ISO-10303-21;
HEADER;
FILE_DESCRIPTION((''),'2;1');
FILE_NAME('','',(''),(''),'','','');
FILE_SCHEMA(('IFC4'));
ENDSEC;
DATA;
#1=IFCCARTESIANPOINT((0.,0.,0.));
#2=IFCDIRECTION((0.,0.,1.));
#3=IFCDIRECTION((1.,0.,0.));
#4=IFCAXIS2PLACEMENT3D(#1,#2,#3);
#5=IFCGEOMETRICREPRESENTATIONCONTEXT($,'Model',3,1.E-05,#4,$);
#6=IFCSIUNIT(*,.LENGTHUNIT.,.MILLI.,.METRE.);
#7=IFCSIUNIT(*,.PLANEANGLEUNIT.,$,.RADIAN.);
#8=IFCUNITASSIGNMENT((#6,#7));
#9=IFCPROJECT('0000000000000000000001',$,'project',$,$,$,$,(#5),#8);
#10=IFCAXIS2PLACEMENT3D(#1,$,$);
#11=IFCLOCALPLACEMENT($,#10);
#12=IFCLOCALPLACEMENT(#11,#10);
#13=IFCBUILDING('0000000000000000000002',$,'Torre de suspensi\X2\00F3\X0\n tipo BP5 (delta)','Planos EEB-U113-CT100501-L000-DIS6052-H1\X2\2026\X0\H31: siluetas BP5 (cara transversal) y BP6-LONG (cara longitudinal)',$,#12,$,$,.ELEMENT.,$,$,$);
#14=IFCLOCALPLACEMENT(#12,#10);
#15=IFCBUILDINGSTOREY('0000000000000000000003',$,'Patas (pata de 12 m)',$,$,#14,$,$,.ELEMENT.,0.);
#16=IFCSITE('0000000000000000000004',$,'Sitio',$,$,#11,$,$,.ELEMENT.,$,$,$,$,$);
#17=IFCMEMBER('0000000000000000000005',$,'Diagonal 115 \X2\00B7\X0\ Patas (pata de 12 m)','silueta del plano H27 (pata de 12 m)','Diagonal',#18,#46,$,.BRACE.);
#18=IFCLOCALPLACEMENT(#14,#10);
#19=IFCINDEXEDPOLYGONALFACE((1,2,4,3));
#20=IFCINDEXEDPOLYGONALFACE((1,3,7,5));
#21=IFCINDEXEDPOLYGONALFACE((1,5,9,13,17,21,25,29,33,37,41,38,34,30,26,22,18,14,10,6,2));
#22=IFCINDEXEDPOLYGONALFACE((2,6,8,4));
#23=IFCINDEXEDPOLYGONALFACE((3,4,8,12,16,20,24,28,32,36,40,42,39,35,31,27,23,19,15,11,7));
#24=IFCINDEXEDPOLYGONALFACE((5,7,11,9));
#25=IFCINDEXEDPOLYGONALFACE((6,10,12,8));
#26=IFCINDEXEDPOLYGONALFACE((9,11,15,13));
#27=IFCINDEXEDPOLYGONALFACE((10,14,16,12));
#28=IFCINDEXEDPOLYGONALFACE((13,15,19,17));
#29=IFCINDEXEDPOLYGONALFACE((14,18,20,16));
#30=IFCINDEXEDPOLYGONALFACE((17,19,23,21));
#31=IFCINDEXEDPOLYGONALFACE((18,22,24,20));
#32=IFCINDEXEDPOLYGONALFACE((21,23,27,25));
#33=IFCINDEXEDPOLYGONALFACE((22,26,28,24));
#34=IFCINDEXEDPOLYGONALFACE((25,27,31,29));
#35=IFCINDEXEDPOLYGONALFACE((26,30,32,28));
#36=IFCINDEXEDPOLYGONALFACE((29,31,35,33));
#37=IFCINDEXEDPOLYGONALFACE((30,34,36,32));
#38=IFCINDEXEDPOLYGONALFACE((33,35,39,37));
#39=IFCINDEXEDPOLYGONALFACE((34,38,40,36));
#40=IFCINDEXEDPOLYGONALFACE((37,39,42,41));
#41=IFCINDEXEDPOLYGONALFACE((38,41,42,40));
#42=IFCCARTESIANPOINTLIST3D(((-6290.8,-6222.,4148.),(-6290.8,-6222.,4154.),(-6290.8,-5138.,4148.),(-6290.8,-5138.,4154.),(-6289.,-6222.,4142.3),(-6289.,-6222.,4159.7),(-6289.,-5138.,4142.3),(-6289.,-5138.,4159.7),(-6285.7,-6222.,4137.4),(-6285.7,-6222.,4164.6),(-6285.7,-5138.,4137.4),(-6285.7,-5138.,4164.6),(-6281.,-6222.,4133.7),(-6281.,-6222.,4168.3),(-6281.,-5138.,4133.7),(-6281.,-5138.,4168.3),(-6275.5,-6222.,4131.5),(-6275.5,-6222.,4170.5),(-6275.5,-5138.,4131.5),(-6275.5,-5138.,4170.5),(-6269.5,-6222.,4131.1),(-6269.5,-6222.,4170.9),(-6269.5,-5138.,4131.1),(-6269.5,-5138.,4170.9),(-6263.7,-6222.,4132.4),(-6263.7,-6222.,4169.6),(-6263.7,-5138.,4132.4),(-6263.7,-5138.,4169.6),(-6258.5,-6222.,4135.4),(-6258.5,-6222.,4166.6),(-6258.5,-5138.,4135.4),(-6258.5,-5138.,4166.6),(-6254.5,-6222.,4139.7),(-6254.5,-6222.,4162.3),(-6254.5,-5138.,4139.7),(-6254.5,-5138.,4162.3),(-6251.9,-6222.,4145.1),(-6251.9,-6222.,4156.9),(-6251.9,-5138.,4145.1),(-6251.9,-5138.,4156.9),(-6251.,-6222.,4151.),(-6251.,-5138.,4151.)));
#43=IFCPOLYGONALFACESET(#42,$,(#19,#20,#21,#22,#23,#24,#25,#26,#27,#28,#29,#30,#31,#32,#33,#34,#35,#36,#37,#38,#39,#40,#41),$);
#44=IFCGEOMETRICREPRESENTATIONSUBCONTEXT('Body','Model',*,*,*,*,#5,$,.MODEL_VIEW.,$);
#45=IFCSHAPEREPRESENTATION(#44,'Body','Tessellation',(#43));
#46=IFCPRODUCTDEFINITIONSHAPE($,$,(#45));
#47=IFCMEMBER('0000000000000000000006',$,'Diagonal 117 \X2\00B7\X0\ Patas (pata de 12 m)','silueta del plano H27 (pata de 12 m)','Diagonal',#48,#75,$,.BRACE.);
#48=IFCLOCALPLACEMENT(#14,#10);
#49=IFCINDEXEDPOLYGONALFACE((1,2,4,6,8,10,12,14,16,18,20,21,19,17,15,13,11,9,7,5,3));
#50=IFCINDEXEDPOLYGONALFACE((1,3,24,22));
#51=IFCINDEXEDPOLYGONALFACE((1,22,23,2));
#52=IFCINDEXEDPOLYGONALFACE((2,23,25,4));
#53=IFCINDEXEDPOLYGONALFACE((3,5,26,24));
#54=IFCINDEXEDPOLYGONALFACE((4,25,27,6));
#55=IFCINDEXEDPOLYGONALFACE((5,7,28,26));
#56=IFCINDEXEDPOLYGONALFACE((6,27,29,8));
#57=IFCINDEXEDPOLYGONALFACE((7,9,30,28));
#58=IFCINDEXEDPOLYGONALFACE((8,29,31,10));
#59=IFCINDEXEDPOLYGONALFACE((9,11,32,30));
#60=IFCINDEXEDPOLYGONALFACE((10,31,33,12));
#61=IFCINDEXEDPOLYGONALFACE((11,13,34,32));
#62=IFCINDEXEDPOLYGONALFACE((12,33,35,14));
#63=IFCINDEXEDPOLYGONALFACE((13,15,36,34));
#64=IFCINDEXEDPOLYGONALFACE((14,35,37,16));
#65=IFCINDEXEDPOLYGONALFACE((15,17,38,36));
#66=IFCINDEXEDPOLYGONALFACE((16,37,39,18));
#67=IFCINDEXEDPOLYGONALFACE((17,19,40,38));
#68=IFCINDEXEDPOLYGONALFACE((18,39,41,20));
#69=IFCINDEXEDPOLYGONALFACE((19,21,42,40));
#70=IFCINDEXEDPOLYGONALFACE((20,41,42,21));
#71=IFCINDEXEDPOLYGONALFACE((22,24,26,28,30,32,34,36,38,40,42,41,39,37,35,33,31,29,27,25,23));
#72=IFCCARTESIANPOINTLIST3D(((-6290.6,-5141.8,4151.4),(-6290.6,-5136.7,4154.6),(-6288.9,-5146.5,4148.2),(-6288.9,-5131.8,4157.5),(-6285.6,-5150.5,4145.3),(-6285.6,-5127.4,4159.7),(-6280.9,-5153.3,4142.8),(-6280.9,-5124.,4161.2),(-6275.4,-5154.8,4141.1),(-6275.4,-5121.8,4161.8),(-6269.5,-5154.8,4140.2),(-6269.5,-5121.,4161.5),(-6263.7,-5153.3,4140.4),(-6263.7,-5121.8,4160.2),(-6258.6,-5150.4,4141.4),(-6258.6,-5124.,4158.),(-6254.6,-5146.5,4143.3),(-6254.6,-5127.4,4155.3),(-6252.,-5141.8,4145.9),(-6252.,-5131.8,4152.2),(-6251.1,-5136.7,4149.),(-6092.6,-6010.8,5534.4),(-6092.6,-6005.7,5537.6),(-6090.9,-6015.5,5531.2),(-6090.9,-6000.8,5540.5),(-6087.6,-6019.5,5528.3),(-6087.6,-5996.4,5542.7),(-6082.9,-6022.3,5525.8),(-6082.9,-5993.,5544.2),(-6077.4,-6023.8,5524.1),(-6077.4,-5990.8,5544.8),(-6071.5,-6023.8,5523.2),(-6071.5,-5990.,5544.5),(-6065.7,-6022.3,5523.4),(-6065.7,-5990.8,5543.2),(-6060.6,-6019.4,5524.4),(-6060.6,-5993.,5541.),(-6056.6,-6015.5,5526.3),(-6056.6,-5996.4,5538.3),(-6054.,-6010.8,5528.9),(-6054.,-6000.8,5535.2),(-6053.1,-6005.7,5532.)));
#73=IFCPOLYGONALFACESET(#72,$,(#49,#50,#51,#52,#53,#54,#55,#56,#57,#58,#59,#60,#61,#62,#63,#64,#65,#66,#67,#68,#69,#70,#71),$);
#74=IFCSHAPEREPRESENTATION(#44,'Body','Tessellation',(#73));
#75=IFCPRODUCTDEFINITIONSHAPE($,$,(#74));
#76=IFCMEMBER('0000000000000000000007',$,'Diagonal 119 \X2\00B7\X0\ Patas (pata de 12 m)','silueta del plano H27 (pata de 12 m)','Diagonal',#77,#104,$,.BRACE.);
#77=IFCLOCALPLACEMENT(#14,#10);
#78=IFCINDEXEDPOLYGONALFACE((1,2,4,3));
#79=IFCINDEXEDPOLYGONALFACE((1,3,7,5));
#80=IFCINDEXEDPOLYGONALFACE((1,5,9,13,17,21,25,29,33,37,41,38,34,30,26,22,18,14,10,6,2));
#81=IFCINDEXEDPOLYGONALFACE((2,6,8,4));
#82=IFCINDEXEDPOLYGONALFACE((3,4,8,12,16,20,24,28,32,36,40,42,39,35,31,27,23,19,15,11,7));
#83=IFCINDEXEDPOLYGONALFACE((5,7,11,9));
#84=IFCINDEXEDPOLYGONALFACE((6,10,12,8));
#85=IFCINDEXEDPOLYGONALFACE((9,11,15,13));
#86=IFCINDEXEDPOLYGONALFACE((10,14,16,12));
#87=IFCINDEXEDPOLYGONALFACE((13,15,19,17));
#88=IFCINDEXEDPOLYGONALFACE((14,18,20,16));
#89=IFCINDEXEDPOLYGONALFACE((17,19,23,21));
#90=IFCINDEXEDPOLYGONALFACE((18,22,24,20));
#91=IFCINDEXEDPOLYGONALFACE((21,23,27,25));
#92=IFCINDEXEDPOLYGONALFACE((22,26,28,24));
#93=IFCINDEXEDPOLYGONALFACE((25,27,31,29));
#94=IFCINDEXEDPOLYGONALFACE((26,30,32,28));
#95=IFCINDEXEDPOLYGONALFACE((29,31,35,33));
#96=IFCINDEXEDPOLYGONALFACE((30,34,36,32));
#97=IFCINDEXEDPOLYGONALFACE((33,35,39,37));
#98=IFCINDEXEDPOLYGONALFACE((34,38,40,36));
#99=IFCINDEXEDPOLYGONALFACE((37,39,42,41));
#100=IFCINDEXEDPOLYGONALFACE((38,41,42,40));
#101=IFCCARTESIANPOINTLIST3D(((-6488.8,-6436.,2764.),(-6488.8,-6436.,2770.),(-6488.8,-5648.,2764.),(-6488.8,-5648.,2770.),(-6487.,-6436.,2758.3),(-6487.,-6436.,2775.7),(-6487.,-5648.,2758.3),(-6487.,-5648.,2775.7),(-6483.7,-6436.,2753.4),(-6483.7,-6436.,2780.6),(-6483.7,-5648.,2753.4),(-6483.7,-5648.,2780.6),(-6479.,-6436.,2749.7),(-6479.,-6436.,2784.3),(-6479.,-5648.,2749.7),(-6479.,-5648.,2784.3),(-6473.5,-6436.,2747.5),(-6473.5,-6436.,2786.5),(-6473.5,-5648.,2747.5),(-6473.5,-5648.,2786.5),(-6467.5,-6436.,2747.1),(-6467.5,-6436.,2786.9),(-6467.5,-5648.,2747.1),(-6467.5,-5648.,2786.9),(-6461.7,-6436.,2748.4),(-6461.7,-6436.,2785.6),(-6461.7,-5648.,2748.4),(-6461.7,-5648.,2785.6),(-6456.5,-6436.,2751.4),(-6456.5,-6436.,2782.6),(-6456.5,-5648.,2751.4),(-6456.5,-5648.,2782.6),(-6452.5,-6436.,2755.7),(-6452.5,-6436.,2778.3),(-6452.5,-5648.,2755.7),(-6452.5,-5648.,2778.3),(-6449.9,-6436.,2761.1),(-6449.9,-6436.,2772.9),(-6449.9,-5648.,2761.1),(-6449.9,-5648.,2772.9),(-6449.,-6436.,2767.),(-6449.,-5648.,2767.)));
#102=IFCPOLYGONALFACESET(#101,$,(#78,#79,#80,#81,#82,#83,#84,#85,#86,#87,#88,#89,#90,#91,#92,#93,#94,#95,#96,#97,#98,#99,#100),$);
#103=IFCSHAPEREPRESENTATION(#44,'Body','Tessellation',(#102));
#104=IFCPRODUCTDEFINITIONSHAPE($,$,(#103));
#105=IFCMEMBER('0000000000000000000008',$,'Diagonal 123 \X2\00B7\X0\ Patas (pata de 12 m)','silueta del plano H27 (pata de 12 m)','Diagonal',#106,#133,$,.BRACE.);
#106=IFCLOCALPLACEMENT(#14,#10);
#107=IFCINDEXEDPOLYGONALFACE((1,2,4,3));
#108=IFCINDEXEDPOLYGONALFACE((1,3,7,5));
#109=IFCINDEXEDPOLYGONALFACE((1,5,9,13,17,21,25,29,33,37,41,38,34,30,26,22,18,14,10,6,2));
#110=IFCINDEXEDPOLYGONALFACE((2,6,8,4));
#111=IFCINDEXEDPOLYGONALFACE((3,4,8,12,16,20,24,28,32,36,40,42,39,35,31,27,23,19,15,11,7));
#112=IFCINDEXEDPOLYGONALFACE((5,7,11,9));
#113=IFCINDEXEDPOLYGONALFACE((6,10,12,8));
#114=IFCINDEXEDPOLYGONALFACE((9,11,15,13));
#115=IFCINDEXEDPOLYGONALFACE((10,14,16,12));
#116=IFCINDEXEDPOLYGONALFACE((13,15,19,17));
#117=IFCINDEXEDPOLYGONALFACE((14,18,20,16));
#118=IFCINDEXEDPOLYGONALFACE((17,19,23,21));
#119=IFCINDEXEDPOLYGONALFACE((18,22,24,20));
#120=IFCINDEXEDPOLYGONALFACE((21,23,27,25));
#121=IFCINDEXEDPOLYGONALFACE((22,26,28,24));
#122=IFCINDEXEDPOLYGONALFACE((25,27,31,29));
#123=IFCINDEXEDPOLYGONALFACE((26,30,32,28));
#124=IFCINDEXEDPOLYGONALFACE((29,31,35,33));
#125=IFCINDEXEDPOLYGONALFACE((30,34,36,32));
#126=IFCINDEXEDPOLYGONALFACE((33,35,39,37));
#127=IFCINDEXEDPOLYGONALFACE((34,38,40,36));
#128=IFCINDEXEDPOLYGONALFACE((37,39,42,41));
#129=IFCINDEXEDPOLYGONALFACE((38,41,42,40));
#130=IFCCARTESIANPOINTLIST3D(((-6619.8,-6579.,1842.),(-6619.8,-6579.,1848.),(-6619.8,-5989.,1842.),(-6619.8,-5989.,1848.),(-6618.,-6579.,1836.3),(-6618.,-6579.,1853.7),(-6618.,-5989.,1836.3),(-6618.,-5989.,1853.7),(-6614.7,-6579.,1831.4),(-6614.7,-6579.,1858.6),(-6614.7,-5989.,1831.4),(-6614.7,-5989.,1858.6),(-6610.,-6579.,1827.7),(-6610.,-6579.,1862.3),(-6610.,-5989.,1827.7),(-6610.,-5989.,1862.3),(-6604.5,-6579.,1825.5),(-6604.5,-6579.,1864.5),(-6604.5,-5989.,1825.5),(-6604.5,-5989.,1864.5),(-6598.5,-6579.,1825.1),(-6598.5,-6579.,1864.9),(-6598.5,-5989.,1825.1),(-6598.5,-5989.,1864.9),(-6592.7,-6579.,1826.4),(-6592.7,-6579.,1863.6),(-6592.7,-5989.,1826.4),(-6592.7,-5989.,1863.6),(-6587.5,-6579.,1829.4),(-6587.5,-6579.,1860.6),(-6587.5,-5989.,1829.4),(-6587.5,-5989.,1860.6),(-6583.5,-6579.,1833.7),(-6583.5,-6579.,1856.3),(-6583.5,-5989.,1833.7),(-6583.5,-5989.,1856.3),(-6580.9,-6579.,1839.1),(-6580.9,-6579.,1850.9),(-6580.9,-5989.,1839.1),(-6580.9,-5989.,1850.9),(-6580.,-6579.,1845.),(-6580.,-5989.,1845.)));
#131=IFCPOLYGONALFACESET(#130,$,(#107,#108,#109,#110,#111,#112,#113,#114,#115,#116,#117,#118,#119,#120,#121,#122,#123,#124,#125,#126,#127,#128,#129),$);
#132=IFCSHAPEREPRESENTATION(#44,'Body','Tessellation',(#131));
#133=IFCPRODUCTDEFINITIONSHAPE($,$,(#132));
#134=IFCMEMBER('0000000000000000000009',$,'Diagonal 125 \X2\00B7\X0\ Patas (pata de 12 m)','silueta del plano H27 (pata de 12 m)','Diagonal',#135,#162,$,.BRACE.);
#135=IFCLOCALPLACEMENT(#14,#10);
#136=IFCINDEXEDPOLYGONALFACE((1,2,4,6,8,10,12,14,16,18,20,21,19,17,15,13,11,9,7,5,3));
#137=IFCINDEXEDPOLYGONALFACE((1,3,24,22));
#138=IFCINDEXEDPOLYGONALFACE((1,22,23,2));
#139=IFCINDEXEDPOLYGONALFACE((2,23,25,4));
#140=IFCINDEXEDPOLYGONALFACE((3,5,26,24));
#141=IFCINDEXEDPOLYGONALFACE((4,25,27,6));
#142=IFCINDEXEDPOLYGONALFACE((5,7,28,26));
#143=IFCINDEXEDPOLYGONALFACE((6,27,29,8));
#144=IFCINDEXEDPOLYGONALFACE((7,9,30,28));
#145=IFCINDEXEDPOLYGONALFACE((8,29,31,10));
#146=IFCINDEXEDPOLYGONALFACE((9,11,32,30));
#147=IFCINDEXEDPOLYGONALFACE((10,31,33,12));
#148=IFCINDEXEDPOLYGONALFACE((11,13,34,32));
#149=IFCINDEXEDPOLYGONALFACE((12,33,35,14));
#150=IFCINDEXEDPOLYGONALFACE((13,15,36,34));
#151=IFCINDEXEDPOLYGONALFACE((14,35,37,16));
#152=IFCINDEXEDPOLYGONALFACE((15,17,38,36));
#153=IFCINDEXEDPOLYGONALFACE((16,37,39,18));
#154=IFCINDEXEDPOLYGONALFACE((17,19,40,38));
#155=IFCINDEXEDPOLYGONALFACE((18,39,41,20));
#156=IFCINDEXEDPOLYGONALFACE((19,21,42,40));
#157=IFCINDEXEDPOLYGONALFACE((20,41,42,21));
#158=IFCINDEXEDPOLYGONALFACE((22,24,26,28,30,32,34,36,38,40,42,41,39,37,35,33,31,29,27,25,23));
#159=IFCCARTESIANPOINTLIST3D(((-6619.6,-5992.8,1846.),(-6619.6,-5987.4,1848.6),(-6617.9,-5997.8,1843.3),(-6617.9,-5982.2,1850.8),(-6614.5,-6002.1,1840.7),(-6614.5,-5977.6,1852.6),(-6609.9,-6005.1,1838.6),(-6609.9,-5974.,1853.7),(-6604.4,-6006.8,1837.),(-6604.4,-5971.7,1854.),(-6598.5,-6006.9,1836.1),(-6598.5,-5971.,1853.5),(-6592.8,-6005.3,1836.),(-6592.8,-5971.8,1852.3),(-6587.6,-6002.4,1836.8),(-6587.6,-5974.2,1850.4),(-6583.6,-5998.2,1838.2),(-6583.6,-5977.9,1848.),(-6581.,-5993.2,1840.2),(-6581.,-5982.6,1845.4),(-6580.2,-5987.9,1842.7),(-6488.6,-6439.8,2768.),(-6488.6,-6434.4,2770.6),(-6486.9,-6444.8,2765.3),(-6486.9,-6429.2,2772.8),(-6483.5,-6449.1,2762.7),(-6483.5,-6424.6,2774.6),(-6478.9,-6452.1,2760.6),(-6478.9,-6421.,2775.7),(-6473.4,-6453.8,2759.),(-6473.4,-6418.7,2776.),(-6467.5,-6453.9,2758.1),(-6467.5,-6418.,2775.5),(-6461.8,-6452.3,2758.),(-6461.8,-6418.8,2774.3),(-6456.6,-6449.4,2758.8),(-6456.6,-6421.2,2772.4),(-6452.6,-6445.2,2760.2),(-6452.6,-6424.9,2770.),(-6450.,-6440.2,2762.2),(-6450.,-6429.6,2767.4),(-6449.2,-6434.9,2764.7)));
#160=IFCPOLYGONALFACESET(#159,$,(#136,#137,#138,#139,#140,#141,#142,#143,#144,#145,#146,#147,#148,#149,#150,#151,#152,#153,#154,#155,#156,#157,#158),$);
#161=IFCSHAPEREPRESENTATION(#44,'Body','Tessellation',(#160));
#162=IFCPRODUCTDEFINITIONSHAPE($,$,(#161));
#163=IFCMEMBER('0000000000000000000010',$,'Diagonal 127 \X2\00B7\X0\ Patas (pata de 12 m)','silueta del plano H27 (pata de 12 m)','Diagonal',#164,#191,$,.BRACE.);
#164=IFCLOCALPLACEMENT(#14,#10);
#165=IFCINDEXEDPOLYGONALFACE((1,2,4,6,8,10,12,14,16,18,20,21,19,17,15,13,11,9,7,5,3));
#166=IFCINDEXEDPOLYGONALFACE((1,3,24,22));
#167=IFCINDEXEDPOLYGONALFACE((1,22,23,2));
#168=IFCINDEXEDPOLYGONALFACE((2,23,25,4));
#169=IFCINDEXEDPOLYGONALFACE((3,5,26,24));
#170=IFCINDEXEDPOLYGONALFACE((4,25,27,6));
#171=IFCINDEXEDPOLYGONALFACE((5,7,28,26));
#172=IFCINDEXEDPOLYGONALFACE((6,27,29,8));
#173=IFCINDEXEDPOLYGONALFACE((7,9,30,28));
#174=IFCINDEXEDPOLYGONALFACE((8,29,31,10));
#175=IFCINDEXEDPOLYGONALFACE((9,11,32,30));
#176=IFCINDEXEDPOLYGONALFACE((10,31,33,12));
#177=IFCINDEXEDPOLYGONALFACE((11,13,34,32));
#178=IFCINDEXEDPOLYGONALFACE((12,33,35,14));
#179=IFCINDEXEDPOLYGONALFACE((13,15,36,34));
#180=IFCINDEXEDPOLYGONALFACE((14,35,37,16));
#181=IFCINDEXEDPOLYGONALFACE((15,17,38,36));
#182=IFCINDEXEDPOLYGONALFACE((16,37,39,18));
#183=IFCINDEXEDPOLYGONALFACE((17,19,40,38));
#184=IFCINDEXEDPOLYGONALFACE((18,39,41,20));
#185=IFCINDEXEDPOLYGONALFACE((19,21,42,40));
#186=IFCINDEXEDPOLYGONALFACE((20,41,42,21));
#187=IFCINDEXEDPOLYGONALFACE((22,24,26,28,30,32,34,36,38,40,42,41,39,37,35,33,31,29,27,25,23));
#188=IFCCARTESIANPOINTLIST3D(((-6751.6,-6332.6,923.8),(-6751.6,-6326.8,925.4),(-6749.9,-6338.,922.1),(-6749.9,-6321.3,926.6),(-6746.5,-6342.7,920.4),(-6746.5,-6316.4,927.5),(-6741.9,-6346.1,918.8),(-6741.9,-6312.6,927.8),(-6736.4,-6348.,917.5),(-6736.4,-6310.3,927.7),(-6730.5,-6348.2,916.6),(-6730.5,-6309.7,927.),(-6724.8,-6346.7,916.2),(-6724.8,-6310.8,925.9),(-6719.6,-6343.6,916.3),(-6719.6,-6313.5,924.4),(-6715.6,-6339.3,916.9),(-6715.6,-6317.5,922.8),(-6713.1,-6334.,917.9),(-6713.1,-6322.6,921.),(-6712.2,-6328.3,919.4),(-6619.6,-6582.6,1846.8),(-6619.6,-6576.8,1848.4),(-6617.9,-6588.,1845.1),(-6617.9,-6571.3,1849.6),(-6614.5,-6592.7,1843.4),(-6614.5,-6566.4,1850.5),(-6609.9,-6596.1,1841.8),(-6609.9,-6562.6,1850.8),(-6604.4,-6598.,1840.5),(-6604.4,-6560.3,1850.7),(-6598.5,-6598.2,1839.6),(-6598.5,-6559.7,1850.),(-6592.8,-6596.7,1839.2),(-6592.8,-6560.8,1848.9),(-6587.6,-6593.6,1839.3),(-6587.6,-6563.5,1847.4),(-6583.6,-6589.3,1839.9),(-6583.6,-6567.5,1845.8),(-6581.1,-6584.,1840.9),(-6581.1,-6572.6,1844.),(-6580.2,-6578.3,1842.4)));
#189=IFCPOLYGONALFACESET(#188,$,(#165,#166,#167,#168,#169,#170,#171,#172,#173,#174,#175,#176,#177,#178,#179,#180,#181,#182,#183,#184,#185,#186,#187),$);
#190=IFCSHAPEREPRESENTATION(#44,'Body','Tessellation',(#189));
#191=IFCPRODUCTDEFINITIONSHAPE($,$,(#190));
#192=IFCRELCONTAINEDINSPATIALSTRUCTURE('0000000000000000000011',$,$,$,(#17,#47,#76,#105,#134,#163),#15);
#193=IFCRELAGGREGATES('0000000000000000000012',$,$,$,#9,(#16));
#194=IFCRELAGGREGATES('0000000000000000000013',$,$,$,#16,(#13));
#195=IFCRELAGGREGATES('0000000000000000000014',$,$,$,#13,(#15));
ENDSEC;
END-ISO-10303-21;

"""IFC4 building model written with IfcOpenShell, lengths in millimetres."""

from ifc_helpers import new_model, si_unit, frame, origin, origin_with_axes, place, context, subcontext, project, spatial, circle, extrude, element, save


model = new_model("IFC4")

# Units and contexts
model_context = context("Model", 3, precision=1e-05, world=origin_with_axes())
body_context = subcontext(model_context, "Body", "Model", "MODEL_VIEW")
ifc_project = project(units=[si_unit("LENGTHUNIT", "METRE", prefix="MILLI"), si_unit("PLANEANGLEUNIT", "RADIAN")], contexts=[model_context])

# Site, building, storey
site_placement = place(None, origin())
site = spatial("IfcSite", under=ifc_project, at=site_placement, Name="Sitio", CompositionType="ELEMENT")
building_placement = place(site_placement, origin())
building = spatial("IfcBuilding", under=site, at=building_placement, Name="Torre de suspensión tipo BP5 (delta)", Description="Planos EEB-U113-CT100501-L000-DIS6052-H1…H31: siluetas BP5 (cara transversal) y BP6-LONG (cara longitudinal)", CompositionType="ELEMENT")
storey_placement = place(building_placement, origin())
storey = spatial("IfcBuildingStorey", under=building, at=storey_placement, Name="Patas (pata de 12 m)", CompositionType="ELEMENT", Elevation=0.0)

# Members
member_1_placement = place(storey_placement, frame((-6271.0, -6222.0, 4151.0), z_axis=(0.0, 1.0, 0.0), x_axis=(1.0, 0.0, 0.0)))
element("IfcMember", 1, at=member_1_placement, inside=storey, Name="Diagonal 115 · Patas (pata de 12 m)", Description="silueta del plano H27 (pata de 12 m)", ObjectType="Diagonal", PredefinedType="BRACE", context=body_context, shape_type="SweptSolid", body=[
    extrude(circle(Radius=20.0), None, (0.0, 0.0, 1.0), 1084.0),
])
member_2_placement = place(storey_placement, frame((-6271.0, -5138.0, 4151.0), z_axis=(0.120342, -0.528167, 0.84057), x_axis=(0.992733, 0.064026, -0.101896)))
element("IfcMember", 2, at=member_2_placement, inside=storey, Name="Diagonal 117 · Patas (pata de 12 m)", Description="silueta del plano H27 (pata de 12 m)", ObjectType="Diagonal", PredefinedType="BRACE", context=body_context, shape_type="SweptSolid", body=[
    extrude(circle(Radius=20.0), None, (0.0, 0.0, 1.0), 1645.3),
])
member_3_placement = place(storey_placement, frame((-6469.0, -6436.0, 2767.0), z_axis=(0.0, 1.0, 0.0), x_axis=(1.0, 0.0, 0.0)))
element("IfcMember", 3, at=member_3_placement, inside=storey, Name="Diagonal 119 · Patas (pata de 12 m)", Description="silueta del plano H27 (pata de 12 m)", ObjectType="Diagonal", PredefinedType="BRACE", context=body_context, shape_type="SweptSolid", body=[
    extrude(circle(Radius=20.0), None, (0.0, 0.0, 1.0), 788.0),
])
member_4_placement = place(storey_placement, frame((-6600.0, -6579.0, 1845.0), z_axis=(0.0, 1.0, 0.0), x_axis=(1.0, 0.0, 0.0)))
element("IfcMember", 4, at=member_4_placement, inside=storey, Name="Diagonal 123 · Patas (pata de 12 m)", Description="silueta del plano H27 (pata de 12 m)", ObjectType="Diagonal", PredefinedType="BRACE", context=body_context, shape_type="SweptSolid", body=[
    extrude(circle(Radius=20.0), None, (0.0, 0.0, 1.0), 590.0),
])
member_5_placement = place(storey_placement, frame((-6600.0, -5989.0, 1845.0), z_axis=(0.126817, -0.432727, 0.892561), x_axis=(0.991926, 0.055324, -0.114113)))
element("IfcMember", 5, at=member_5_placement, inside=storey, Name="Diagonal 125 · Patas (pata de 12 m)", Description="silueta del plano H27 (pata de 12 m)", ObjectType="Diagonal", PredefinedType="BRACE", context=body_context, shape_type="SweptSolid", body=[
    extrude(circle(Radius=20.0), None, (0.0, 0.0, 1.0), 1033.0),
])
member_6_placement = place(storey_placement, frame((-6732.0, -6329.0, 922.0), z_axis=(0.136741, -0.25898, 0.956154), x_axis=(0.990607, 0.035749, -0.131986)))
element("IfcMember", 6, at=member_6_placement, inside=storey, Name="Diagonal 127 · Patas (pata de 12 m)", Description="silueta del plano H27 (pata de 12 m)", ObjectType="Diagonal", PredefinedType="BRACE", context=body_context, shape_type="SweptSolid", body=[
    extrude(circle(Radius=20.0), None, (0.0, 0.0, 1.0), 965.3),
])

save(model, "model.ifc")
